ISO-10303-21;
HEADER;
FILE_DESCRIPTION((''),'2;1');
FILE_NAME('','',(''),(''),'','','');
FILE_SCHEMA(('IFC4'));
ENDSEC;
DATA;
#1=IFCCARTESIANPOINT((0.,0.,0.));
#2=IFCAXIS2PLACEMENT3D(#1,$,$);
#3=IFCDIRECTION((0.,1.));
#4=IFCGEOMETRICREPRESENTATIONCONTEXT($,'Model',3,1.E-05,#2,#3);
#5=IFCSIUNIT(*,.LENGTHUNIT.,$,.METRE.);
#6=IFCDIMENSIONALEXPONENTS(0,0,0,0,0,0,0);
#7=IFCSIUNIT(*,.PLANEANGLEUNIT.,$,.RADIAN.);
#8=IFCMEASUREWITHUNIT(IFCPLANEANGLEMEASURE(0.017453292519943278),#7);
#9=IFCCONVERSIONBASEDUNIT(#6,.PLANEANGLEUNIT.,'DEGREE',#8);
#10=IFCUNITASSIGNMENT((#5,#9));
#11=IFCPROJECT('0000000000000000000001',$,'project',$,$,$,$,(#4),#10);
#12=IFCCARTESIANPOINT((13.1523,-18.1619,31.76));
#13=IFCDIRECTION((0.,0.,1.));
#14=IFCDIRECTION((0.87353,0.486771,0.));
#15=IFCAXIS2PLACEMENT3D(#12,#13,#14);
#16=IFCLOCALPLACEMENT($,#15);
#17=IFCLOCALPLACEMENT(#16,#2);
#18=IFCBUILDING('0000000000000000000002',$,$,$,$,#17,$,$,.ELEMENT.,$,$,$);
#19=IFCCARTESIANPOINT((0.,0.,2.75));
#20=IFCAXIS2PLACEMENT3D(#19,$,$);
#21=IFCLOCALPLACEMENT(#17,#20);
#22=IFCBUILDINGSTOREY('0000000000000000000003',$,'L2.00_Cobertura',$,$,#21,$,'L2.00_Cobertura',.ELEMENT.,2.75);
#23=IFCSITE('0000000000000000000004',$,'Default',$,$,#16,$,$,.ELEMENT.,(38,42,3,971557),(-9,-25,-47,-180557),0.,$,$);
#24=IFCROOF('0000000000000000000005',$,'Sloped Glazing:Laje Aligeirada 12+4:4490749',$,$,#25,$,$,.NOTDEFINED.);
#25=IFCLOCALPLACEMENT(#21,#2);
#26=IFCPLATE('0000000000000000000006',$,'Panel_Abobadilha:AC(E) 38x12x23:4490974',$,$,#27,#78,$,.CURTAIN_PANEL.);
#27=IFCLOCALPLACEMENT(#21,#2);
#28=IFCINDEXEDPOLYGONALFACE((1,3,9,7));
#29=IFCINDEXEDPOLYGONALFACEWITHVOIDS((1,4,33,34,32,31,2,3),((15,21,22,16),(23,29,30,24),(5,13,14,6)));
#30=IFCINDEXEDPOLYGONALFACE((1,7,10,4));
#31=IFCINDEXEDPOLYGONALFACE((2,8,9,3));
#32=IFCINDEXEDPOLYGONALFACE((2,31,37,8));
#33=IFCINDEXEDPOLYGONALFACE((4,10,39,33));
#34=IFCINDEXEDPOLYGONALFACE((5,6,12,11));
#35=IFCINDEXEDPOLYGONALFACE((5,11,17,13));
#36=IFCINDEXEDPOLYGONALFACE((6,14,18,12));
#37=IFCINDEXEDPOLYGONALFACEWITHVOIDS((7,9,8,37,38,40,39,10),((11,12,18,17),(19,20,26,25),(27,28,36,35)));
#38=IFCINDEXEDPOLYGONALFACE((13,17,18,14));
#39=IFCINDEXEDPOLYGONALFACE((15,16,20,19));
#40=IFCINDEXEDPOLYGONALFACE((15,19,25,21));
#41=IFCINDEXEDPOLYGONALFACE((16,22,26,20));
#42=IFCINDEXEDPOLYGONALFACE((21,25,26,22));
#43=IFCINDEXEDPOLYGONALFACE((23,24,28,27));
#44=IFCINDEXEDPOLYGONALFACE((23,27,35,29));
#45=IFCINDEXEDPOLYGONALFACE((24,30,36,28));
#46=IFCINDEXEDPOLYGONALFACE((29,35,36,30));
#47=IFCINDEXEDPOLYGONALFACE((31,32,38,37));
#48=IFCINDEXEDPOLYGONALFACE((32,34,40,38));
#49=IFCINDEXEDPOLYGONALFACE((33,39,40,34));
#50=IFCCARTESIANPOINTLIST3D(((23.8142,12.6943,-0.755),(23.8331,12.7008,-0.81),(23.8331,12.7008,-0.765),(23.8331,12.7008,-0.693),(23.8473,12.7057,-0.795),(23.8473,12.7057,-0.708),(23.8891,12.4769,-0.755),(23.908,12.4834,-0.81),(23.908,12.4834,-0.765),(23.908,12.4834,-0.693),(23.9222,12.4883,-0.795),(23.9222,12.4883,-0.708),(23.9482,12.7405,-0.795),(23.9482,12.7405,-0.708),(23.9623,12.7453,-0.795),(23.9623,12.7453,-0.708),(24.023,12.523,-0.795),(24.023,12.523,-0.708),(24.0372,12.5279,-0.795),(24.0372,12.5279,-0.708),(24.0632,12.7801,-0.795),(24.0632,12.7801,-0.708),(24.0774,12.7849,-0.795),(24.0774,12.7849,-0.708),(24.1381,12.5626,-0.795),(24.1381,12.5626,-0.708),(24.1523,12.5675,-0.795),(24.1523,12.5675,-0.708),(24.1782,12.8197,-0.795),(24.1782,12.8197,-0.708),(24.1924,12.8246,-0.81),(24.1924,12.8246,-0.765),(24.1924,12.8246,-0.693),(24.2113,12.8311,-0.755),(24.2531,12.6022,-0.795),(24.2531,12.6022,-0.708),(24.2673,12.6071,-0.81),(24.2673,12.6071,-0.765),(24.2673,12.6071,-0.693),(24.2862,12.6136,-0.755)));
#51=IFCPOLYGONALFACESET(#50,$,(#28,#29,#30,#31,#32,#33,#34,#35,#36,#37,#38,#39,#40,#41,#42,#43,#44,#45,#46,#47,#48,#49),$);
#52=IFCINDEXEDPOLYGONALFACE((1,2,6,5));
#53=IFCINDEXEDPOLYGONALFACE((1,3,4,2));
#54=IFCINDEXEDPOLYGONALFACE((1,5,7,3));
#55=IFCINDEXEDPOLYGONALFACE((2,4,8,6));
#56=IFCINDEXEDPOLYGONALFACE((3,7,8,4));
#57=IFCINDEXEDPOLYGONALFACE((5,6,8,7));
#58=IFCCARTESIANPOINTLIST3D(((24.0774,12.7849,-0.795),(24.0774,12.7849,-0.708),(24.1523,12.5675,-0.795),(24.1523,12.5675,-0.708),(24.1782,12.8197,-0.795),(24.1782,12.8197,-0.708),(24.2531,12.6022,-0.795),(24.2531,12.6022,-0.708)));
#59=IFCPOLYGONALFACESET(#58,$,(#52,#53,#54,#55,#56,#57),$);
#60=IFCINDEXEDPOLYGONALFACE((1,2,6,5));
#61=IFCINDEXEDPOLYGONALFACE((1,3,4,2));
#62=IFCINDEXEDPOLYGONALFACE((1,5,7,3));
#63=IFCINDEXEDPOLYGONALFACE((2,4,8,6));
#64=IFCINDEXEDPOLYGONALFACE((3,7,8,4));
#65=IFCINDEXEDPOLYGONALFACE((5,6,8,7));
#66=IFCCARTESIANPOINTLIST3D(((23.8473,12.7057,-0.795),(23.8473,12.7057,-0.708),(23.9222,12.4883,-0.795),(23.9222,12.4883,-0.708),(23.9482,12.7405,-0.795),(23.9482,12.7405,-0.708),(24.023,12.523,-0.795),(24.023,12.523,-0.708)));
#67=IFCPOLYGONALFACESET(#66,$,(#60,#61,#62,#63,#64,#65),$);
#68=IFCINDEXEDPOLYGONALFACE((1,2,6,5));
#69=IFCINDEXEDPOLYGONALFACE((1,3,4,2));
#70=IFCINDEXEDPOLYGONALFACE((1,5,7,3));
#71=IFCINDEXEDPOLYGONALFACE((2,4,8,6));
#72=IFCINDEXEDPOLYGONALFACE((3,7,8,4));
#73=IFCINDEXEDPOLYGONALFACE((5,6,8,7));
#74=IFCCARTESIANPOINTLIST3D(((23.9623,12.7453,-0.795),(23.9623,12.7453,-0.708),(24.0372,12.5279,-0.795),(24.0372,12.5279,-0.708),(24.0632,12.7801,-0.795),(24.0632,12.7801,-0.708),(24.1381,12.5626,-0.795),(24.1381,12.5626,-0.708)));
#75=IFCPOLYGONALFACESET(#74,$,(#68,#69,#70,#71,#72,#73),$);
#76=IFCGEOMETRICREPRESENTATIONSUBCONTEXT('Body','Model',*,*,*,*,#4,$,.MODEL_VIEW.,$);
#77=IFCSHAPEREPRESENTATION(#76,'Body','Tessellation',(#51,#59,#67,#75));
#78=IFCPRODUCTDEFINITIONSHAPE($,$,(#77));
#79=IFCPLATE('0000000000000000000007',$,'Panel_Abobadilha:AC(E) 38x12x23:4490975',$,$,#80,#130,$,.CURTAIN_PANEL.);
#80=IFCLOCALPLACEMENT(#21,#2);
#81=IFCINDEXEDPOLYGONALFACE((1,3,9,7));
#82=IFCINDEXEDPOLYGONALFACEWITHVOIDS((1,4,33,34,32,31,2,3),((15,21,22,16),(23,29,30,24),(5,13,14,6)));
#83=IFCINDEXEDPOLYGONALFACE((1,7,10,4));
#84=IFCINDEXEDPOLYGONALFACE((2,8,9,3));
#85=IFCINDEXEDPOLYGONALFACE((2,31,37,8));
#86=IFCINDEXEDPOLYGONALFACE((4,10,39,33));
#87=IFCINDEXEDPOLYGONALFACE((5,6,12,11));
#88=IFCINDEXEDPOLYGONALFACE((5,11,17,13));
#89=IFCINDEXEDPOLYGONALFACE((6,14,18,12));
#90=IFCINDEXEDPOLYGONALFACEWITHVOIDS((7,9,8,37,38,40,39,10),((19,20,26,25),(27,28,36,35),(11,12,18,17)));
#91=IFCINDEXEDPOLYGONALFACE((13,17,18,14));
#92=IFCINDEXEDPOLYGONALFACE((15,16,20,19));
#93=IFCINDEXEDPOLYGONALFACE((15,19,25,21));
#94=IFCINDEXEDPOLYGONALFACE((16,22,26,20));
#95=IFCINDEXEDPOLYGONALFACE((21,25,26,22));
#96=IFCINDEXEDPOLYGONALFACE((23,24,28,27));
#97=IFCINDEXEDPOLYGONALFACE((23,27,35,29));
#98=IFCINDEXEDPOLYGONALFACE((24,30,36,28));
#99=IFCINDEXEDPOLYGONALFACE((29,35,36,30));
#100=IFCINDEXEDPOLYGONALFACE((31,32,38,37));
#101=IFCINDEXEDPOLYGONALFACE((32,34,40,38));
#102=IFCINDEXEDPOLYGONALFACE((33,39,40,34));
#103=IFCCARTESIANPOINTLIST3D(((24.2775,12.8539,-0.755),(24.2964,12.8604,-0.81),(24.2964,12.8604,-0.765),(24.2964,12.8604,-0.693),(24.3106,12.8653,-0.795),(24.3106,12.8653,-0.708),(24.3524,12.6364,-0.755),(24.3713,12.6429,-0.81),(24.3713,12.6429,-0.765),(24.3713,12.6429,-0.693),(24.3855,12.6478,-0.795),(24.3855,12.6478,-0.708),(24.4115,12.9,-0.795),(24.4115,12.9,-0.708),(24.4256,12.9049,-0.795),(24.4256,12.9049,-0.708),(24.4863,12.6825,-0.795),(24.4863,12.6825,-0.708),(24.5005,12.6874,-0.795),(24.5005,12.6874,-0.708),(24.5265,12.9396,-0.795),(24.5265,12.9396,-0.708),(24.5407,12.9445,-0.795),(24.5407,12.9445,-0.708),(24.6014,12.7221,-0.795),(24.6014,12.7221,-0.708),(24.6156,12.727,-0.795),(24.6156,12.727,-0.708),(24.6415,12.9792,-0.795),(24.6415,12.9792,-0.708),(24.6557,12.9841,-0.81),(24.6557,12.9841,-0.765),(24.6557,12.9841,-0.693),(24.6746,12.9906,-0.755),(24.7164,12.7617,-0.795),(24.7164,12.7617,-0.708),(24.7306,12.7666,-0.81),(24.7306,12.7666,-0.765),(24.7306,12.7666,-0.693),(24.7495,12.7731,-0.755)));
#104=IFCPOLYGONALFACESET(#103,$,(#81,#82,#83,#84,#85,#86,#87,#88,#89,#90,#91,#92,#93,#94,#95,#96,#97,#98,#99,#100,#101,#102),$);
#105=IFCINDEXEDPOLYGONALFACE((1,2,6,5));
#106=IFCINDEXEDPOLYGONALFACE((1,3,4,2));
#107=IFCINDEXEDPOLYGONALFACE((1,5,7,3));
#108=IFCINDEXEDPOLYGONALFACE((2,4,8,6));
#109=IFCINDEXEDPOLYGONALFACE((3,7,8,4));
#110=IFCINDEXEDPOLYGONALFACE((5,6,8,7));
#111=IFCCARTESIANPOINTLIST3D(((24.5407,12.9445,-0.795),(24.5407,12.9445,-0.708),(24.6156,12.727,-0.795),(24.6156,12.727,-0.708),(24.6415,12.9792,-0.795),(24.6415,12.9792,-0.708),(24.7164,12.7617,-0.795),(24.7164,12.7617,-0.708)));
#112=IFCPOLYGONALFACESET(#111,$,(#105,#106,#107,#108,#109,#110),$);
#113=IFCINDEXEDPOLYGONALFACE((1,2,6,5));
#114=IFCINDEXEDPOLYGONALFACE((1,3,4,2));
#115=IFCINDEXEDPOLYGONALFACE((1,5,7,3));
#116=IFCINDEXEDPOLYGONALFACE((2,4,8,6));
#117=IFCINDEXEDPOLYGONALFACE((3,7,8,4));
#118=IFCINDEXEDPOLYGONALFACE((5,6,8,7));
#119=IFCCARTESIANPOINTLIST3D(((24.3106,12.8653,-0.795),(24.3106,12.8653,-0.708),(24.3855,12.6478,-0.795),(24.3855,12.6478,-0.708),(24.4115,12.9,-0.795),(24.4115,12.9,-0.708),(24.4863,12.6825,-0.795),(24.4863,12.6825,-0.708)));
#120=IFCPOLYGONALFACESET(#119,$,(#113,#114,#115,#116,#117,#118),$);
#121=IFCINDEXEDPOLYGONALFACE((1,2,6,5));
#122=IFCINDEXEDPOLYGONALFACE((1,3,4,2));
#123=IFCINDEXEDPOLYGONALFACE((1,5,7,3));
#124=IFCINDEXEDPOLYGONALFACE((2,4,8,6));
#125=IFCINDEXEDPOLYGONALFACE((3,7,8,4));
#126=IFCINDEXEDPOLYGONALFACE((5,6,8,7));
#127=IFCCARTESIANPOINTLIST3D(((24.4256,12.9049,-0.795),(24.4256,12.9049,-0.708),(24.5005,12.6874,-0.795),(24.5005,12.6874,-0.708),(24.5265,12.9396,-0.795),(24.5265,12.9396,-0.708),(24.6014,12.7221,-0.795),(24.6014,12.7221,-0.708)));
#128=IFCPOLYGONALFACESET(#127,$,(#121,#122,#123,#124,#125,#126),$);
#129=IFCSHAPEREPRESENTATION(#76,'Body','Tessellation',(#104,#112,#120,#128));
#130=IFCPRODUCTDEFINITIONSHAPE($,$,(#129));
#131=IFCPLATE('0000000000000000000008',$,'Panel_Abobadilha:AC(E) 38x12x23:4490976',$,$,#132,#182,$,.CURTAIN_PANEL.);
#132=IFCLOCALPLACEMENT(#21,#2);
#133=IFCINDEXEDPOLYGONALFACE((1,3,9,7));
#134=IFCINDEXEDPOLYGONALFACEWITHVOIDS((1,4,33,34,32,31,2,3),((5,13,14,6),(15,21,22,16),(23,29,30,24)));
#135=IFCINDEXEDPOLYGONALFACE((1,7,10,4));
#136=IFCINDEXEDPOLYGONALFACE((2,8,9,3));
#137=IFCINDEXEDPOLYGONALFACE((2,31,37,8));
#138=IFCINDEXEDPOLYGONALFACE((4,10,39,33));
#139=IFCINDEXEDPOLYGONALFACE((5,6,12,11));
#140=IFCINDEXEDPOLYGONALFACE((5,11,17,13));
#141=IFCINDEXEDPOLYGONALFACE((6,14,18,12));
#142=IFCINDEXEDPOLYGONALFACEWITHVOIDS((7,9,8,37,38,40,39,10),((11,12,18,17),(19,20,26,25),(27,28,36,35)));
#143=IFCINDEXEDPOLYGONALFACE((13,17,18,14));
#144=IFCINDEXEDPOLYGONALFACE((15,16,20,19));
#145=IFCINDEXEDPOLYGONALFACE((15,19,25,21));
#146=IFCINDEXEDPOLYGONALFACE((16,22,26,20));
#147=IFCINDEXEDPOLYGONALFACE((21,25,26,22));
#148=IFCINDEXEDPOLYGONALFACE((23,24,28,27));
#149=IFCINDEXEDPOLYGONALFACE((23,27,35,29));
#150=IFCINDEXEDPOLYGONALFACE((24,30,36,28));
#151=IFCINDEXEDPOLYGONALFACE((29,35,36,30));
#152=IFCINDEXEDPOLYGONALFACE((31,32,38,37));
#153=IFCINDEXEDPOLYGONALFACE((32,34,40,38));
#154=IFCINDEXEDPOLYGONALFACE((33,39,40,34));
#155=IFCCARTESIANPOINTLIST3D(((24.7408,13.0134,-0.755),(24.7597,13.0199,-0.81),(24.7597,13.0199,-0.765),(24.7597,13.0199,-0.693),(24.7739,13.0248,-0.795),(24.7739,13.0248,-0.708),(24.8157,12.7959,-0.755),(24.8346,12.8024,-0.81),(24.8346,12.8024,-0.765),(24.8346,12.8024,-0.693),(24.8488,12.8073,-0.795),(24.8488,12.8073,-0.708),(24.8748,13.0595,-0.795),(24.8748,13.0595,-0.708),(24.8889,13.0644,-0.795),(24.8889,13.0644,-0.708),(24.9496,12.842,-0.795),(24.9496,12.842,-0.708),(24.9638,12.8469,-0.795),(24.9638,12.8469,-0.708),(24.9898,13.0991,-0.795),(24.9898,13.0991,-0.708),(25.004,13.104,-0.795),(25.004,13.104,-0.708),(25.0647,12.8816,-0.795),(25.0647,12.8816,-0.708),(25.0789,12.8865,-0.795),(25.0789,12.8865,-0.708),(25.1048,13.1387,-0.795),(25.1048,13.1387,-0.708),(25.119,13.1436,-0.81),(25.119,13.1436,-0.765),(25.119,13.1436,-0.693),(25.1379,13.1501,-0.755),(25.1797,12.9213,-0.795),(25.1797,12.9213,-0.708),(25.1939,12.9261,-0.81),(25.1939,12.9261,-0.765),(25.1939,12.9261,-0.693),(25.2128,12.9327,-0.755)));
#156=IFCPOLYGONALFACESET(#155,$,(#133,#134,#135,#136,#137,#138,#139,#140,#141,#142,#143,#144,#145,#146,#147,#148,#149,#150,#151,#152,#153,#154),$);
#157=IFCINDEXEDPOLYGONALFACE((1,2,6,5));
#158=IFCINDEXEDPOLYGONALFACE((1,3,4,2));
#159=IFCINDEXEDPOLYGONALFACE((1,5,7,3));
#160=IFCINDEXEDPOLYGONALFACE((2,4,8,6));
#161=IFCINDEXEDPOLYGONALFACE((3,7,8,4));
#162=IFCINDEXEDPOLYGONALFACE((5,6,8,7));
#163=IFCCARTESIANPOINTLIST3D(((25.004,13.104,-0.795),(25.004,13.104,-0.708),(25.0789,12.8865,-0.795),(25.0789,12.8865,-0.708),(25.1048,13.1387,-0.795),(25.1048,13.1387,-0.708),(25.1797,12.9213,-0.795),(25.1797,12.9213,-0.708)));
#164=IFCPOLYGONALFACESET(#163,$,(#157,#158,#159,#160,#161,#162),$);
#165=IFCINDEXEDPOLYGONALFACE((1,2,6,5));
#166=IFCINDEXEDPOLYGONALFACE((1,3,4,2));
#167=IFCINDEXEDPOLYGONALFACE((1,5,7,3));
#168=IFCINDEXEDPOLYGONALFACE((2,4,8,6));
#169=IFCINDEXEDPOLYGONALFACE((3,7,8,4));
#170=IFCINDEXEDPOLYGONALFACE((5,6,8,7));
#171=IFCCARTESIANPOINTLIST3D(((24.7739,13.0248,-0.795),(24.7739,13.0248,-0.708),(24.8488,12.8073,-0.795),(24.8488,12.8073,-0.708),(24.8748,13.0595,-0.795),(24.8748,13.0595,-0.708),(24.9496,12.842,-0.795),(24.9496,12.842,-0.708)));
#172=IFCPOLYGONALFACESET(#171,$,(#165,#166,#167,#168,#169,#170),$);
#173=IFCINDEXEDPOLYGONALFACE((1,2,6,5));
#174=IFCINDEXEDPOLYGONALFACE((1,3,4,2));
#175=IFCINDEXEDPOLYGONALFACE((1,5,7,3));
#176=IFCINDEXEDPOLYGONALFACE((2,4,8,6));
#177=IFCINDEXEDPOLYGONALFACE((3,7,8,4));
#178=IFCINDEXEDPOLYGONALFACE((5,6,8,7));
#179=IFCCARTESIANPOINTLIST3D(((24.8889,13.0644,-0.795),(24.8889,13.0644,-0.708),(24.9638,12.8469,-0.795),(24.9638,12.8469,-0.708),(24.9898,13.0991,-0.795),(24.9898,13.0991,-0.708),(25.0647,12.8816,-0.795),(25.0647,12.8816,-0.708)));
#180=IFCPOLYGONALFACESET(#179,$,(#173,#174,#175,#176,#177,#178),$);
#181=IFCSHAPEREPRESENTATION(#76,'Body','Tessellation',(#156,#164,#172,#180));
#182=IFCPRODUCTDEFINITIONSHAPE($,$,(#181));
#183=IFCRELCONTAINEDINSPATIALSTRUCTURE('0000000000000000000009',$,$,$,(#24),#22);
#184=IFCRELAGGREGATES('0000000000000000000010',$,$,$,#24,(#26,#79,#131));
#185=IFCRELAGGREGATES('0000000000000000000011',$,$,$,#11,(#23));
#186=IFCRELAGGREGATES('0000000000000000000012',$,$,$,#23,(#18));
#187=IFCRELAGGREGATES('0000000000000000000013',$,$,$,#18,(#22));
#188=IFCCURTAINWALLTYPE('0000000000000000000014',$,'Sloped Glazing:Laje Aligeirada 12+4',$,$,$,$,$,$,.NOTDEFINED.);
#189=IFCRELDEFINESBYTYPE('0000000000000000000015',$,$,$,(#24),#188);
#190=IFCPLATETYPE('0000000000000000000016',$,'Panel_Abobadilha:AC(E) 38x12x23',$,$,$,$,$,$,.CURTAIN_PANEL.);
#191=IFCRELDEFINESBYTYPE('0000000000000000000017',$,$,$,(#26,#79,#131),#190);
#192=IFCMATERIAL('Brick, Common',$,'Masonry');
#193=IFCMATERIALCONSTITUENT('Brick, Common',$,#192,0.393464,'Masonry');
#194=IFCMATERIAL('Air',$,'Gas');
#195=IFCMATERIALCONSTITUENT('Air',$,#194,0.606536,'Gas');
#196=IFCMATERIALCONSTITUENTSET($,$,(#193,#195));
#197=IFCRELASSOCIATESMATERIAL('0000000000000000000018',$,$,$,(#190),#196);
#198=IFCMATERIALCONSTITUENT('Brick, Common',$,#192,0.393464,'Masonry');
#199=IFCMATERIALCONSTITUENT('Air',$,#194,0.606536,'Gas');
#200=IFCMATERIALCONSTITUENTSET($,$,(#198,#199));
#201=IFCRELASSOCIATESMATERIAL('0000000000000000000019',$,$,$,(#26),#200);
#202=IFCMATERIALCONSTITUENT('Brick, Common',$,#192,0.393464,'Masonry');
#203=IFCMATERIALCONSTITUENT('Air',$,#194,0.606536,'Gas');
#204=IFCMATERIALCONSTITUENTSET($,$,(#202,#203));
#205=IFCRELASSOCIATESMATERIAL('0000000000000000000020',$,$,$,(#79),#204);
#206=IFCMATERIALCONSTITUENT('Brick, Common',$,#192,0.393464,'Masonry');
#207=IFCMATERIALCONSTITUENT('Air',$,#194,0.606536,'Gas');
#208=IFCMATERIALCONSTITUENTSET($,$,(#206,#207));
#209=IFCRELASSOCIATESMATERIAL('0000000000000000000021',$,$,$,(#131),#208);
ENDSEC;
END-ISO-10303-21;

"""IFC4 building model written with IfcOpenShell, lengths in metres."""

from ifc_helpers import new_model, entity, si_unit, converted_unit, direction, frame, origin, place, context, subcontext, project, spatial, indexed_curve, outline, extrude, source, transform, mapped, material, constituent, constituent_set, type_object, type_shapes, element, aggregate, save


model = new_model("IFC4")

# Units and contexts
model_context = context("Model", 3, precision=1e-05, world=origin(), true_north=direction((0.0, 1.0)))
body_context = subcontext(model_context, "Body", "Model", "MODEL_VIEW")
ifc_project = project(units=[si_unit("LENGTHUNIT", "METRE"), converted_unit("PLANEANGLEUNIT", "DEGREE", entity("IfcPlaneAngleMeasure", 0.017453292519943278), si_unit("PLANEANGLEUNIT", "RADIAN"), dimensions=[0, 0, 0, 0, 0, 0, 0])], contexts=[model_context])

# Site, building, storey
site_placement = place(None, frame((13.1523, -18.1619, 31.76), z_axis=(0.0, 0.0, 1.0), x_axis=(0.87353, 0.486771, 0.0)))
site = spatial("IfcSite", under=ifc_project, at=site_placement, Name="Default", CompositionType="ELEMENT", RefLatitude=(38, 42, 3, 971557), RefLongitude=(-9, -25, -47, -180557), RefElevation=0.0)
building_placement = place(site_placement, origin())
building = spatial("IfcBuilding", under=site, at=building_placement, CompositionType="ELEMENT")
storey_placement = place(building_placement, frame((0.0, 0.0, 2.75)))
storey = spatial("IfcBuildingStorey", under=building, at=storey_placement, Name="L2.00_Cobertura", LongName="L2.00_Cobertura", CompositionType="ELEMENT", Elevation=2.75)

# Roof, plates
curtain_wall_type = type_object("IfcCurtainWallType", Name="Sloped Glazing:Laje Aligeirada 12+4", PredefinedType="NOTDEFINED")
roof_placement = place(storey_placement, frame((0.0, 0.0, -2.75)))
roof = element("IfcRoof", 1, at=roof_placement, inside=storey, type_object=curtain_wall_type, Name="Sloped Glazing:Laje Aligeirada 12+4:4490749", PredefinedType="NOTDEFINED")
ifc_material_1 = material(Name="Brick, Common", Category="Masonry")
ifc_material_2 = material(Name="Air", Category="Gas")
ifc_constituent_1 = constituent(ifc_material_1, Name="Brick, Common", Category="Masonry", fraction=0.393464)
ifc_constituent_2 = constituent(ifc_material_2, Name="Air", Category="Gas", fraction=0.606536)
ifc_constituent_set_1 = constituent_set(constituents=[ifc_constituent_1, ifc_constituent_2])
plate_type = type_object("IfcPlateType", Name="Panel_Abobadilha:AC(E) 38x12x23", PredefinedType="CURTAIN_PANEL", material=ifc_constituent_set_1)
shared_shape_1 = source(origin(), body_context, "Body", "SweptSolid", [
    extrude(outline(indexed_curve([(-0.19, -0.0543), (0.19, -0.0543), (0.19, -0.0093), (0.21, 0.0007), (0.19, 0.0628), (-0.19, 0.0628), (-0.21, 0.0007), (-0.19, -0.0093), (-0.19, -0.0543)], self_intersect=False), holes=[indexed_curve([(-0.0683, 0.0477), (-0.0683, -0.0393), (-0.175, -0.0393), (-0.175, 0.0477), (-0.0683, 0.0477)], self_intersect=False), indexed_curve([(0.0533, 0.0477), (0.0533, -0.0393), (-0.0533, -0.0393), (-0.0533, 0.0477), (0.0533, 0.0477)], self_intersect=False), indexed_curve([(0.175, 0.0477), (0.175, -0.0393), (0.0683, -0.0393), (0.0683, 0.0477), (0.175, 0.0477)], self_intersect=False)]), frame((0.0, 0.0543, 0.0)), (0.0, 0.0, 1.0), 0.23),
    extrude(outline(indexed_curve([(-0.0533, -0.0435), (0.0533, -0.0435), (0.0533, 0.0435), (-0.0533, 0.0435), (-0.0533, -0.0435)], self_intersect=False)), frame((0.1217, 0.0585, 0.0), z_axis=(0.0, 0.0, 1.0), x_axis=(-1.0, 0.0, 0.0)), (0.0, 0.0, 1.0), 0.23),
    extrude(outline(indexed_curve([(-0.0533, -0.0435), (0.0533, -0.0435), (0.0533, 0.0435), (-0.0533, 0.0435), (-0.0533, -0.0435)], self_intersect=False)), frame((-0.1217, 0.0585, 0.0), z_axis=(0.0, 0.0, 1.0), x_axis=(-1.0, 0.0, 0.0)), (0.0, 0.0, 1.0), 0.23),
    extrude(outline(indexed_curve([(-0.0533, -0.0435), (0.0533, -0.0435), (0.0533, 0.0435), (-0.0533, 0.0435), (-0.0533, -0.0435)], self_intersect=False)), frame((0.0, 0.0585, 0.0), z_axis=(0.0, 0.0, 1.0), x_axis=(-1.0, 0.0, 0.0)), (0.0, 0.0, 1.0), 0.23),
])
type_shapes(plate_type, [shared_shape_1])
ifc_constituent_3 = constituent(ifc_material_1, Name="Brick, Common", Category="Masonry", fraction=0.393464)
ifc_constituent_4 = constituent(ifc_material_2, Name="Air", Category="Gas", fraction=0.606536)
ifc_constituent_set_2 = constituent_set(constituents=[ifc_constituent_3, ifc_constituent_4])
plate_1_placement = place(roof_placement, frame((24.0128, 12.7627, 1.94), z_axis=(0.325568, -0.945519, 0.0), x_axis=(0.945519, 0.325568, 0.0)))
plate_1 = element("IfcPlate", 2, at=plate_1_placement, type_object=plate_type, material=ifc_constituent_set_2, Name="Panel_Abobadilha:AC(E) 38x12x23:4490974", PredefinedType="CURTAIN_PANEL", context=body_context, shape_type="MappedRepresentation", body=[
    mapped(shared_shape_1, transform((0.0, 0.0, 0.0), scale=1.0)),
])
ifc_constituent_5 = constituent(ifc_material_1, Name="Brick, Common", Category="Masonry", fraction=0.393464)
ifc_constituent_6 = constituent(ifc_material_2, Name="Air", Category="Gas", fraction=0.606536)
ifc_constituent_set_3 = constituent_set(constituents=[ifc_constituent_5, ifc_constituent_6])
plate_2_placement = place(roof_placement, frame((24.4761, 12.9222, 1.94), z_axis=(0.325568, -0.945519, 0.0), x_axis=(0.945519, 0.325568, 0.0)))
plate_2 = element("IfcPlate", 3, at=plate_2_placement, type_object=plate_type, material=ifc_constituent_set_3, Name="Panel_Abobadilha:AC(E) 38x12x23:4490975", PredefinedType="CURTAIN_PANEL", context=body_context, shape_type="MappedRepresentation", body=[
    mapped(shared_shape_1, transform((0.0, 0.0, 0.0), scale=1.0)),
])
ifc_constituent_7 = constituent(ifc_material_1, Name="Brick, Common", Category="Masonry", fraction=0.393464)
ifc_constituent_8 = constituent(ifc_material_2, Name="Air", Category="Gas", fraction=0.606536)
ifc_constituent_set_4 = constituent_set(constituents=[ifc_constituent_7, ifc_constituent_8])
plate_3_placement = place(roof_placement, frame((24.9394, 13.0818, 1.94), z_axis=(0.325568, -0.945519, 0.0), x_axis=(0.945519, 0.325568, 0.0)))
plate_3 = element("IfcPlate", 4, at=plate_3_placement, type_object=plate_type, material=ifc_constituent_set_4, Name="Panel_Abobadilha:AC(E) 38x12x23:4490976", PredefinedType="CURTAIN_PANEL", context=body_context, shape_type="MappedRepresentation", body=[
    mapped(shared_shape_1, transform((0.0, 0.0, 0.0), scale=1.0)),
])
aggregate(roof, [plate_1, plate_2, plate_3])

save(model, "model.ifc")
